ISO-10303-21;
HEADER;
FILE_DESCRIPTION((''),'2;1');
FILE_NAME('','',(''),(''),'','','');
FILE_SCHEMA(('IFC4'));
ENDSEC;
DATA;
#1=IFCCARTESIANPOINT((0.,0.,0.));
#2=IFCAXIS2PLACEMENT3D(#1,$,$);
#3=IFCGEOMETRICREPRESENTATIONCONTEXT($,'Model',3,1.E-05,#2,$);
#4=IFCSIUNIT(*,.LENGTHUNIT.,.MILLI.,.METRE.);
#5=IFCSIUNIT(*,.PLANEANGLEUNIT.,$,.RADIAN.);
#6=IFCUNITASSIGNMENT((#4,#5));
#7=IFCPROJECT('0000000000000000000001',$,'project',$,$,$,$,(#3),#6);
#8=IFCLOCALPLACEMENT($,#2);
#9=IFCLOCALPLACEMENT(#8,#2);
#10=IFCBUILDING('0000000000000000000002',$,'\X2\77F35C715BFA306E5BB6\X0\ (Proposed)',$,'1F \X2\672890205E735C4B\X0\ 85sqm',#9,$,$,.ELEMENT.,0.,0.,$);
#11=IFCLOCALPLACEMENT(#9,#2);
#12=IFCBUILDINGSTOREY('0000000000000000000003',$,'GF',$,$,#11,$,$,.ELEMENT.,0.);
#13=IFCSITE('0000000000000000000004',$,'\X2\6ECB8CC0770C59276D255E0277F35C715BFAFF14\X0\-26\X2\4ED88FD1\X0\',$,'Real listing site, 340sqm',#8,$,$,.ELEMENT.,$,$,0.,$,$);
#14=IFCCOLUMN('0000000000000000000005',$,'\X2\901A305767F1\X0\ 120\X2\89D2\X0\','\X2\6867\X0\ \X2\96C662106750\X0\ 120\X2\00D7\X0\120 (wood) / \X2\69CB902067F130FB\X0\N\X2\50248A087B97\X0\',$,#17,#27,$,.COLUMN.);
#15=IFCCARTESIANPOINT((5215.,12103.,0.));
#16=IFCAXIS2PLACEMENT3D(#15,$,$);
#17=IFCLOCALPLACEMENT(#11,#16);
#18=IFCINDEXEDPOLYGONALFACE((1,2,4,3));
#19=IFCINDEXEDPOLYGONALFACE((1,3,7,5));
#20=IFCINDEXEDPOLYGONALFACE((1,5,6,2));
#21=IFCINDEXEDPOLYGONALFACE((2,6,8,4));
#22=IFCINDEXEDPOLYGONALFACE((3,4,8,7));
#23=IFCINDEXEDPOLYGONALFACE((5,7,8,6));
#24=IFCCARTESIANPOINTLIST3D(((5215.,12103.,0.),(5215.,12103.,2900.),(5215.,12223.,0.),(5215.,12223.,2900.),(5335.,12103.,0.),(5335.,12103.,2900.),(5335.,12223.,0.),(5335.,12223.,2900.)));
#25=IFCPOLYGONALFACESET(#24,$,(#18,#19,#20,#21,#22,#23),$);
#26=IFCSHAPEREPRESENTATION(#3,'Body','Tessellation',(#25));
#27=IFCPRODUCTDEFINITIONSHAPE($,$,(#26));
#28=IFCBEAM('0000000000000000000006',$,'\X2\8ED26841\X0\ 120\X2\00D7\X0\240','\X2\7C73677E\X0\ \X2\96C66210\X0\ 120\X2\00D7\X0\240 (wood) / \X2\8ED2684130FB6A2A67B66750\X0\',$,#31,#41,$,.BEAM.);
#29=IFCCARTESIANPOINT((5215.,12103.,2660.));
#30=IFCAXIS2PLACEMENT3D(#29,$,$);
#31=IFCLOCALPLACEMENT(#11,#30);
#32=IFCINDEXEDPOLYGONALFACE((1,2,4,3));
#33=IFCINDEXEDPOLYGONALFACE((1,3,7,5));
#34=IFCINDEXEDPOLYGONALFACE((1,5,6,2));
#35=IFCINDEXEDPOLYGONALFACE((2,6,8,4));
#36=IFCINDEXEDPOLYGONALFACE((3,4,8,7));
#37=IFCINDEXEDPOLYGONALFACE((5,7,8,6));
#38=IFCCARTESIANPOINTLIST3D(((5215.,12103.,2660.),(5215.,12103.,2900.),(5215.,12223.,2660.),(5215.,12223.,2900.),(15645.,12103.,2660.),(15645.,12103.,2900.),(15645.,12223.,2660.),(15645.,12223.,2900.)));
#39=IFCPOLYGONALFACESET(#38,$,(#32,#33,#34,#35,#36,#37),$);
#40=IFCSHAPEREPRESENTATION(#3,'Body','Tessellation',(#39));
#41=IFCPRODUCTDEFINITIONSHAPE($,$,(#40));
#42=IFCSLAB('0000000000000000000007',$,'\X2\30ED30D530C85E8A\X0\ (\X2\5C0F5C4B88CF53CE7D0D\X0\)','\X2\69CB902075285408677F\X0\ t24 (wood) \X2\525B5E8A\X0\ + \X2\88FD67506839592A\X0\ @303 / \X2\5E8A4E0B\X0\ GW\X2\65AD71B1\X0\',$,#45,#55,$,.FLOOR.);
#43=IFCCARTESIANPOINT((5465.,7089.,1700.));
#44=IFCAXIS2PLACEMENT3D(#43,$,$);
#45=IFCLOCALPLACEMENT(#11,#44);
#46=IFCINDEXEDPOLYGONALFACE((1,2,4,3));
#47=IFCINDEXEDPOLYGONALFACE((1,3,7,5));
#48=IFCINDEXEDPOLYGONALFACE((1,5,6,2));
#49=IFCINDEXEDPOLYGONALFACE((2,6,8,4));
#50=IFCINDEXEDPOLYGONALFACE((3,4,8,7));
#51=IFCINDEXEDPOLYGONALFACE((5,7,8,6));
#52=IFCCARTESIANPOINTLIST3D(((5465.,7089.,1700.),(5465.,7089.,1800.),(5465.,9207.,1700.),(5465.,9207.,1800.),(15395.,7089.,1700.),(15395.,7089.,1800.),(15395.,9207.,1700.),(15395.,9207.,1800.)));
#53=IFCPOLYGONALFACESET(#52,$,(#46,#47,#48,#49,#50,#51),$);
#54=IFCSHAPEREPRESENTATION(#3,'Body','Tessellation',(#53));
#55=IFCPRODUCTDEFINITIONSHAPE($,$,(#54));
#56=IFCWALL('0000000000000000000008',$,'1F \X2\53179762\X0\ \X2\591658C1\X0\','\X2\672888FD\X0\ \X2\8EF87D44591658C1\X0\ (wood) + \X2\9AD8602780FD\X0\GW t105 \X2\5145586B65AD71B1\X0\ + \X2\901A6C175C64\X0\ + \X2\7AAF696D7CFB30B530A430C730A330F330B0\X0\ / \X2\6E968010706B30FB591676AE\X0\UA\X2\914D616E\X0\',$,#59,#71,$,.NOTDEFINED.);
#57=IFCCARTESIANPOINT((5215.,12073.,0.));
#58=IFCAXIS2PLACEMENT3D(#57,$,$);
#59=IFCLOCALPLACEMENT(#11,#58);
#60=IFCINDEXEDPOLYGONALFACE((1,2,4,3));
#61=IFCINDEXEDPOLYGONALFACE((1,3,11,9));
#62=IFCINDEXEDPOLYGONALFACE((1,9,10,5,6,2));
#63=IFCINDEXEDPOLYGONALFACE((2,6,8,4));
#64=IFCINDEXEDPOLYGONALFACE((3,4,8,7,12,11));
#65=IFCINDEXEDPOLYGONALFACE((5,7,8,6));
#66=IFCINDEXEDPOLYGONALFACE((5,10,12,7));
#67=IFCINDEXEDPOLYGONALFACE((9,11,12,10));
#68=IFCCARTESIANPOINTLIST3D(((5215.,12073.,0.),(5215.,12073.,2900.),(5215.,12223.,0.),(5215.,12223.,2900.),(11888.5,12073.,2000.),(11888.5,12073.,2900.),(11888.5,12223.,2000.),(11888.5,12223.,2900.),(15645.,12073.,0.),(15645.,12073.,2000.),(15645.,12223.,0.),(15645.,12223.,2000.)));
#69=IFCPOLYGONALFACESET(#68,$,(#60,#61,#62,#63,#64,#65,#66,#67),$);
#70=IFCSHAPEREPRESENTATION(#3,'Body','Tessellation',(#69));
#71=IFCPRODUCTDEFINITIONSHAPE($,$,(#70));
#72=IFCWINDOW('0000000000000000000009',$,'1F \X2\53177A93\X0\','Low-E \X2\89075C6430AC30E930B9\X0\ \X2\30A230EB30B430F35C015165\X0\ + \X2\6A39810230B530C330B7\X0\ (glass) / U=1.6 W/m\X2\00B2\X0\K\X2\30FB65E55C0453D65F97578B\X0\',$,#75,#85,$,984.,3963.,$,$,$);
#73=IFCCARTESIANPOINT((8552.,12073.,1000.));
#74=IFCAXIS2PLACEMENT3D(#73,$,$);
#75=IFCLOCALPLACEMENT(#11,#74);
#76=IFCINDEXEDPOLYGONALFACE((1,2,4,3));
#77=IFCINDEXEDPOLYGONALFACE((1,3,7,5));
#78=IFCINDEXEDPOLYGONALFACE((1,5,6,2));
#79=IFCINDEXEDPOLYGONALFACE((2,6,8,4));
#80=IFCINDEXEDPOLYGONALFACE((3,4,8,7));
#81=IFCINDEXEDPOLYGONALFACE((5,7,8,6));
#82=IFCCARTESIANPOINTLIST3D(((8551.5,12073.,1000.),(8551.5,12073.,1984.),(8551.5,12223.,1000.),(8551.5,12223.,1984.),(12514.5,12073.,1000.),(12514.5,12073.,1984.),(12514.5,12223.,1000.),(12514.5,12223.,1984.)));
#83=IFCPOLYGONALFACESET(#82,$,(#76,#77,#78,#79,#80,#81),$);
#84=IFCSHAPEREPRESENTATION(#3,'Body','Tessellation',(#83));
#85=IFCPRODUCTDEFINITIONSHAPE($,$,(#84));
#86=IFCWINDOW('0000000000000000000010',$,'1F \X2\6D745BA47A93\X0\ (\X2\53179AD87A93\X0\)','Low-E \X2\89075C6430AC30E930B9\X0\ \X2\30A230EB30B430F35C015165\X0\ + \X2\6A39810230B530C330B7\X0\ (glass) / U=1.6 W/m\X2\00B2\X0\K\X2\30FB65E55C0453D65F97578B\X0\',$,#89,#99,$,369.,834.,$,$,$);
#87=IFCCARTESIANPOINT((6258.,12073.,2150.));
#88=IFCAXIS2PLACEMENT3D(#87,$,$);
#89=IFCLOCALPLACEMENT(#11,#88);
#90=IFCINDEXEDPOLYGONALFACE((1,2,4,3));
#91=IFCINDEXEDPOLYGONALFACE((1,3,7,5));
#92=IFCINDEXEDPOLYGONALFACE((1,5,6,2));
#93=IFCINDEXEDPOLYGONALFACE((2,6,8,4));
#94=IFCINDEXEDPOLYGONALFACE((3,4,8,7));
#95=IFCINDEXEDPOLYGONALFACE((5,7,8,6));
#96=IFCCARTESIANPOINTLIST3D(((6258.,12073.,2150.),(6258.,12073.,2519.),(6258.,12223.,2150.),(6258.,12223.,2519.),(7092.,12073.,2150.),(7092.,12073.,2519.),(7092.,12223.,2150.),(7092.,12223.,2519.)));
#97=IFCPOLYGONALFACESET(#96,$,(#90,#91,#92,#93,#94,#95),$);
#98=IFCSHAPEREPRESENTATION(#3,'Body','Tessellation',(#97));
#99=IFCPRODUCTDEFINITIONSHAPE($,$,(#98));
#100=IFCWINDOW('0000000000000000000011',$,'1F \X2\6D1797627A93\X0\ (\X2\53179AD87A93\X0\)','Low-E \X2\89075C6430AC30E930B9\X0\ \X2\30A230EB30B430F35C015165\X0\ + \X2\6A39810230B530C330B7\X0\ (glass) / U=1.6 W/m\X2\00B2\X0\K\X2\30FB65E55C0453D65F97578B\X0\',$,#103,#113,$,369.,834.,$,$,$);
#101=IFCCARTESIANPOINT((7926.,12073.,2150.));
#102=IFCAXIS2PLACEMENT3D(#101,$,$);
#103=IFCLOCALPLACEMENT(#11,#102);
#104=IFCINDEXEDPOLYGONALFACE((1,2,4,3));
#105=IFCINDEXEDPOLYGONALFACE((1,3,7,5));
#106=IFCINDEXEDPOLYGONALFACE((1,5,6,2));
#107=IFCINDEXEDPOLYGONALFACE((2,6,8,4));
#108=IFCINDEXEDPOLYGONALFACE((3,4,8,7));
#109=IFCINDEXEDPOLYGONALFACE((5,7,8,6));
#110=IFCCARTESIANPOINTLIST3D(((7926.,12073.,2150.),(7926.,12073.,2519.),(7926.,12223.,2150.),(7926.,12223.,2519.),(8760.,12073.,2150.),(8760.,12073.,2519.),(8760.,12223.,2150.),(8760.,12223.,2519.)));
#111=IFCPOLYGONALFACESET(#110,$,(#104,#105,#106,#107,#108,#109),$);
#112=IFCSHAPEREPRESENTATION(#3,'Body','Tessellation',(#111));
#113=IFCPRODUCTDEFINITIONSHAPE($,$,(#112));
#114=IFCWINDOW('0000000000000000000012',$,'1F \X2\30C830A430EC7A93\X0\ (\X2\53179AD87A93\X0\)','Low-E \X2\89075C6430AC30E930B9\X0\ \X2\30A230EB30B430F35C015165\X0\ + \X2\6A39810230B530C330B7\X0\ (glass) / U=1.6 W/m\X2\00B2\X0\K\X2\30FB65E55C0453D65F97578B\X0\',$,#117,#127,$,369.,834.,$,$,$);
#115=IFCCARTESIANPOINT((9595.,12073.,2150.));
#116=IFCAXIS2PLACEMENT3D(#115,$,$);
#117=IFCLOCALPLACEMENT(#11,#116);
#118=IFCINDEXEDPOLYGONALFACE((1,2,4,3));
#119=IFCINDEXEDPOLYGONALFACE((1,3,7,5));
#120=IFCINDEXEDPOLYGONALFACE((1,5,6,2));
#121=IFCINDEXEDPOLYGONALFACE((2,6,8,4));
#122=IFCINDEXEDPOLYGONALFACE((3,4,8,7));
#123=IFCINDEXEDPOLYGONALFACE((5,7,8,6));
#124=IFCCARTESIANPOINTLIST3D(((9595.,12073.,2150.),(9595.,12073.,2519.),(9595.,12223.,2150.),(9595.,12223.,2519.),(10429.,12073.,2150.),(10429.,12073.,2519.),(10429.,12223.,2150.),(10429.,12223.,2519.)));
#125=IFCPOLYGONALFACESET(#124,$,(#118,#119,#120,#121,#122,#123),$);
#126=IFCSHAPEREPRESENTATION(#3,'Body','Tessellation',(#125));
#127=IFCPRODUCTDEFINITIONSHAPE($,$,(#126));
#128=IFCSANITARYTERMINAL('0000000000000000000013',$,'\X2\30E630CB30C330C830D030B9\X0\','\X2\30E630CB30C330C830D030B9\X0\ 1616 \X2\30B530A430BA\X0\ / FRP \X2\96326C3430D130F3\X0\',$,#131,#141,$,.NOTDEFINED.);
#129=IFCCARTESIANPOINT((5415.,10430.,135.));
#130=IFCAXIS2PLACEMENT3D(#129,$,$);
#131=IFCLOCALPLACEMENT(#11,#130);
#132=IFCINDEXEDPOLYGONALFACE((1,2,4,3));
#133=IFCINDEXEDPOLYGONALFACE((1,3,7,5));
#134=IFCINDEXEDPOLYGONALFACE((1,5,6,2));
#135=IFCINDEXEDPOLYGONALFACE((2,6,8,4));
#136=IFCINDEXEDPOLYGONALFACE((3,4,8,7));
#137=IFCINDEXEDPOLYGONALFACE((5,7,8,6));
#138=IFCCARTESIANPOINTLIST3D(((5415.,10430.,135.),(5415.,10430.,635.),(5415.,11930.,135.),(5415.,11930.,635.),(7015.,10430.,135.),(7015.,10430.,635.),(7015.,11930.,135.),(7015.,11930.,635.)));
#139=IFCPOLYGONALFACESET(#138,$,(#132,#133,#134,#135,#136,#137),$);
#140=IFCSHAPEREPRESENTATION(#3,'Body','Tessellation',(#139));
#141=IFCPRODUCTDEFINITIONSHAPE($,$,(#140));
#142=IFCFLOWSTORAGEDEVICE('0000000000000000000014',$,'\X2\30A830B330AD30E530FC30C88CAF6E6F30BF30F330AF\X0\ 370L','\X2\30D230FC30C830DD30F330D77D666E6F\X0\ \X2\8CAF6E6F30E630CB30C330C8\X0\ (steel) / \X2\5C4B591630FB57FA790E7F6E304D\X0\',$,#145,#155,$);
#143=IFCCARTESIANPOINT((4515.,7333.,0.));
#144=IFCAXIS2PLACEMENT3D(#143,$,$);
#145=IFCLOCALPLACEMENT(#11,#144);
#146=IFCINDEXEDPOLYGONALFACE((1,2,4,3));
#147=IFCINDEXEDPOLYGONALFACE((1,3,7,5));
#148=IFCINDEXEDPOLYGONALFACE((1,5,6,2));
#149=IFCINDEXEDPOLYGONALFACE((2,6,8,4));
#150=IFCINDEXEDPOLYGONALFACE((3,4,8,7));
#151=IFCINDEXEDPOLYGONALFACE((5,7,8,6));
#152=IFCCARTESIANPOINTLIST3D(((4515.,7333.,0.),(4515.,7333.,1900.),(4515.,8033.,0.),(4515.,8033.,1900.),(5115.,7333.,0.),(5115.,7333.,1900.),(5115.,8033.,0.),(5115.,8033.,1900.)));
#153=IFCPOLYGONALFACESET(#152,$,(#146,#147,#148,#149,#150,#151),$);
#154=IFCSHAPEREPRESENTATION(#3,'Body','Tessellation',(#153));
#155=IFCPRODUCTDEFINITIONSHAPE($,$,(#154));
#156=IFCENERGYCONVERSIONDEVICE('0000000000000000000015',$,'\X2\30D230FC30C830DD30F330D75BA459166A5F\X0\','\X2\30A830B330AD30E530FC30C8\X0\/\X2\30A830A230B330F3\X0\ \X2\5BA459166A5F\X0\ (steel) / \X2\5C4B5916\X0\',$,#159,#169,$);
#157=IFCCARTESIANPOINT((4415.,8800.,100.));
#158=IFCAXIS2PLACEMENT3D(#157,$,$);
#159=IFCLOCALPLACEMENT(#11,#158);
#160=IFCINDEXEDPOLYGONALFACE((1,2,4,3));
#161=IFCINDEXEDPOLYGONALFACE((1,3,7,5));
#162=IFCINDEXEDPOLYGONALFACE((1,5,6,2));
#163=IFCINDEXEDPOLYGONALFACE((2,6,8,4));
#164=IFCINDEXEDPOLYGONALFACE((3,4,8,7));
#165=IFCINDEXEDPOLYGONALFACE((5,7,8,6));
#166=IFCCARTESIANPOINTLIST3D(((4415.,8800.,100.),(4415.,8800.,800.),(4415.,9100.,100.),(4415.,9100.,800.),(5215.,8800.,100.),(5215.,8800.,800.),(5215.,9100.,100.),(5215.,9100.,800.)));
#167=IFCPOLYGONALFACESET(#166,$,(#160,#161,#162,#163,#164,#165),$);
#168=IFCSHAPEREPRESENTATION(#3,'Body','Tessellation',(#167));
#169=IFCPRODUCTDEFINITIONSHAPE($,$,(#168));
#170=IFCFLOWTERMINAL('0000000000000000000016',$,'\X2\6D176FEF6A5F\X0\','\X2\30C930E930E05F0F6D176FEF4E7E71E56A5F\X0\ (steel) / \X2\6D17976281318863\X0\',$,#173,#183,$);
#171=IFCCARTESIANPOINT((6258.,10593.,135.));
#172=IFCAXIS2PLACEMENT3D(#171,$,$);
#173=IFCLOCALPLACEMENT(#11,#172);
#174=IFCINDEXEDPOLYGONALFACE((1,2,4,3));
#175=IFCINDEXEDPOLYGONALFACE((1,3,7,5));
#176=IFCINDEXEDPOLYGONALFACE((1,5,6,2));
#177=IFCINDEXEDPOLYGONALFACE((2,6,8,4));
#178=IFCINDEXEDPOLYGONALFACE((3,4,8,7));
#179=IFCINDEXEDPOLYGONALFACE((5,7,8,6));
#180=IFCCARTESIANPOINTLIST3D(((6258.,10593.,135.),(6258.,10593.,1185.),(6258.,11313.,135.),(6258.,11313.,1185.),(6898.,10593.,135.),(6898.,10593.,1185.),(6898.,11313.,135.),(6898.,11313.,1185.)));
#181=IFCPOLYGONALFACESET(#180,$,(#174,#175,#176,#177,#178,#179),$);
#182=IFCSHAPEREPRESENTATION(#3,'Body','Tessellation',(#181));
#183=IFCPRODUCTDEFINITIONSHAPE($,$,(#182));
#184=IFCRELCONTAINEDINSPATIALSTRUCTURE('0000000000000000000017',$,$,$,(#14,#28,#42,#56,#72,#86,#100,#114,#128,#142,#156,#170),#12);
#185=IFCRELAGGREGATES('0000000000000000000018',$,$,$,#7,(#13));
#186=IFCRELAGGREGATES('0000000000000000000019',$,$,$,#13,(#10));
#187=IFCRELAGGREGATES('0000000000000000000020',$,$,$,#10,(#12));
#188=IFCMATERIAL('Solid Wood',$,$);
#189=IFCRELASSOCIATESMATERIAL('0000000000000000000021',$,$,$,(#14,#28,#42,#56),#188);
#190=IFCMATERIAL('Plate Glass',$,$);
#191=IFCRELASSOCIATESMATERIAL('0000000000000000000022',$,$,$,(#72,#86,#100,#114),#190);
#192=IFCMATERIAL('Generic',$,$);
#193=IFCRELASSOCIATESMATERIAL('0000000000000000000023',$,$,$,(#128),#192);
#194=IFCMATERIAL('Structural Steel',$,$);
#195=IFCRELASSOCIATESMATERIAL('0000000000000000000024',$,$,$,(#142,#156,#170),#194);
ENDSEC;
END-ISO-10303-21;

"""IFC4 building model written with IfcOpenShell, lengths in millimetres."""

from ifc_helpers import new_model, si_unit, frame, frame_2d, origin, place, context, project, spatial, rectangle, extrude, material, element, fill, save


model = new_model("IFC4")

# Units and contexts
model_context = context("Model", 3, precision=1e-05, world=origin())
ifc_project = project(units=[si_unit("LENGTHUNIT", "METRE", prefix="MILLI"), si_unit("PLANEANGLEUNIT", "RADIAN")], contexts=[model_context])

# Site, building, storey
site_placement = place(None, origin())
site = spatial("IfcSite", under=ifc_project, at=site_placement, Name="滋賀県大津市石山寺４-26付近", ObjectType="Real listing site, 340sqm", CompositionType="ELEMENT", RefElevation=0.0)
building_placement = place(site_placement, origin())
building = spatial("IfcBuilding", under=site, at=building_placement, Name="石山寺の家 (Proposed)", ObjectType="1F 木造平屋 85sqm", CompositionType="ELEMENT", ElevationOfRefHeight=0.0, ElevationOfTerrain=0.0)
storey_placement = place(building_placement, origin())
storey = spatial("IfcBuildingStorey", under=building, at=storey_placement, Name="GF", CompositionType="ELEMENT", Elevation=0.0)

# Column
ifc_material_1 = material(Name="Solid Wood")
column_1_placement = place(storey_placement, frame((5215.0, 12103.0, 0.0)))
element("IfcColumn", 1, at=column_1_placement, inside=storey, material=ifc_material_1, Name="通し柱 120角", Description="桧 集成材 120×120 (wood) / 構造柱・N値計算", PredefinedType="COLUMN", context=model_context, shape_type="SweptSolid", body=[
    extrude(rectangle(XDim=120.0, YDim=120.0, at=frame_2d((60.0, 60.0))), frame((5215.0, 12103.0, 0.0)), (0.0, 0.0, 1.0), 2900.0),
])

# Beam
beam_1_placement = place(storey_placement, frame((5215.0, 12103.0, 2660.0)))
element("IfcBeam", 2, at=beam_1_placement, inside=storey, material=ifc_material_1, Name="軒桁 120×240", Description="米松 集成 120×240 (wood) / 軒桁・横架材", PredefinedType="BEAM", context=model_context, shape_type="SweptSolid", body=[
    extrude(rectangle(XDim=10430.0, YDim=120.0, at=frame_2d((5215.0, 60.0))), frame((5215.0, 12103.0, 2660.0)), (0.0, 0.0, 1.0), 240.0),
])

# Slab
slab_placement = place(storey_placement, frame((5465.0, 7089.0, 1700.0)))
element("IfcSlab", 3, at=slab_placement, inside=storey, material=ifc_material_1, Name="ロフト床 (小屋裏収納)", Description="構造用合板 t24 (wood) 剛床 + 製材根太 @303 / 床下 GW断熱", PredefinedType="FLOOR", context=model_context, shape_type="SweptSolid", body=[
    extrude(rectangle(XDim=9930.0, YDim=2118.0, at=frame_2d((4965.0, 1059.0))), frame((5465.0, 7089.0, 1700.0)), (0.0, 0.0, 1.0), 100.0),
])

# Wall, openings, windows
wall_1_placement = place(storey_placement, frame((5215.0, 12073.0, 0.0)))
wall_1 = element("IfcWall", 4, at=wall_1_placement, inside=storey, material=ifc_material_1, Name="1F 北面 外壁", Description="木製 軸組外壁 (wood) + 高性能GW t105 充填断熱 + 通気層 + 窯業系サイディング / 準耐火・外皮UA配慮", PredefinedType="NOTDEFINED", context=model_context, shape_type="SweptSolid", body=[
    extrude(rectangle(XDim=10430.0, YDim=150.0, at=frame_2d((5215.0, 75.0))), frame((5215.0, 12073.0, 0.0)), (0.0, 0.0, 1.0), 2900.0),
])
opening_1_placement = place(storey_placement, frame((8552.0, 12073.0, 1000.0)))
opening_1 = element("IfcOpeningElement", 5, at=opening_1_placement, cuts=wall_1, PredefinedType="NOTDEFINED", context=model_context, shape_type="SweptSolid", body=[
    extrude(rectangle(XDim=3963.0, YDim=150.0, at=frame_2d((1981.0, 75.0))), frame((8552.0, 12073.0, 1000.0)), (0.0, 0.0, 1.0), 984.0),
])
opening_2_placement = place(storey_placement, frame((6258.0, 12073.0, 2150.0)))
opening_2 = element("IfcOpeningElement", 6, at=opening_2_placement, cuts=wall_1, PredefinedType="NOTDEFINED", context=model_context, shape_type="SweptSolid", body=[
    extrude(rectangle(XDim=834.0, YDim=150.0, at=frame_2d((417.0, 75.0))), frame((6258.0, 12073.0, 2150.0)), (0.0, 0.0, 1.0), 369.0),
])
opening_3_placement = place(storey_placement, frame((7926.0, 12073.0, 2150.0)))
opening_3 = element("IfcOpeningElement", 7, at=opening_3_placement, cuts=wall_1, PredefinedType="NOTDEFINED", context=model_context, shape_type="SweptSolid", body=[
    extrude(rectangle(XDim=834.0, YDim=150.0, at=frame_2d((417.0, 75.0))), frame((7926.0, 12073.0, 2150.0)), (0.0, 0.0, 1.0), 369.0),
])
opening_4_placement = place(storey_placement, frame((9595.0, 12073.0, 2150.0)))
opening_4 = element("IfcOpeningElement", 8, at=opening_4_placement, cuts=wall_1, PredefinedType="NOTDEFINED", context=model_context, shape_type="SweptSolid", body=[
    extrude(rectangle(XDim=834.0, YDim=150.0, at=frame_2d((417.0, 75.0))), frame((9595.0, 12073.0, 2150.0)), (0.0, 0.0, 1.0), 369.0),
])
ifc_material_2 = material(Name="Plate Glass")
window_1_placement = place(storey_placement, frame((8552.0, 12073.0, 1000.0)))
window_1 = element("IfcWindow", 9, at=window_1_placement, inside=storey, material=ifc_material_2, Name="1F 北窓", Description="Low-E 複層ガラス アルゴン封入 + 樹脂サッシ (glass) / U=1.6 W/m²K・日射取得型", OverallHeight=984.0, OverallWidth=3963.0, context=model_context, shape_type="SweptSolid", body=[
    extrude(rectangle(XDim=3963.0, YDim=150.0, at=frame_2d((1981.0, 75.0))), frame((8552.0, 12073.0, 1000.0)), (0.0, 0.0, 1.0), 984.0),
])
fill(opening_1, window_1)
window_2_placement = place(storey_placement, frame((6258.0, 12073.0, 2150.0)))
window_2 = element("IfcWindow", 10, at=window_2_placement, inside=storey, material=ifc_material_2, Name="1F 浴室窓 (北高窓)", Description="Low-E 複層ガラス アルゴン封入 + 樹脂サッシ (glass) / U=1.6 W/m²K・日射取得型", OverallHeight=369.0, OverallWidth=834.0, context=model_context, shape_type="SweptSolid", body=[
    extrude(rectangle(XDim=834.0, YDim=150.0, at=frame_2d((417.0, 75.0))), frame((6258.0, 12073.0, 2150.0)), (0.0, 0.0, 1.0), 369.0),
])
fill(opening_2, window_2)
window_3_placement = place(storey_placement, frame((7926.0, 12073.0, 2150.0)))
window_3 = element("IfcWindow", 11, at=window_3_placement, inside=storey, material=ifc_material_2, Name="1F 洗面窓 (北高窓)", Description="Low-E 複層ガラス アルゴン封入 + 樹脂サッシ (glass) / U=1.6 W/m²K・日射取得型", OverallHeight=369.0, OverallWidth=834.0, context=model_context, shape_type="SweptSolid", body=[
    extrude(rectangle(XDim=834.0, YDim=150.0, at=frame_2d((417.0, 75.0))), frame((7926.0, 12073.0, 2150.0)), (0.0, 0.0, 1.0), 369.0),
])
fill(opening_3, window_3)
window_4_placement = place(storey_placement, frame((9595.0, 12073.0, 2150.0)))
window_4 = element("IfcWindow", 12, at=window_4_placement, inside=storey, material=ifc_material_2, Name="1F トイレ窓 (北高窓)", Description="Low-E 複層ガラス アルゴン封入 + 樹脂サッシ (glass) / U=1.6 W/m²K・日射取得型", OverallHeight=369.0, OverallWidth=834.0, context=model_context, shape_type="SweptSolid", body=[
    extrude(rectangle(XDim=834.0, YDim=150.0, at=frame_2d((417.0, 75.0))), frame((9595.0, 12073.0, 2150.0)), (0.0, 0.0, 1.0), 369.0),
])
fill(opening_4, window_4)

# Sanitary terminal
ifc_material_3 = material(Name="Generic")
sanitary_terminal_placement = place(storey_placement, frame((5415.0, 10430.0, 135.0)))
element("IfcSanitaryTerminal", 13, at=sanitary_terminal_placement, inside=storey, material=ifc_material_3, Name="ユニットバス", Description="ユニットバス 1616 サイズ / FRP 防水パン", PredefinedType="NOTDEFINED", context=model_context, shape_type="SweptSolid", body=[
    extrude(rectangle(XDim=1600.0, YDim=1500.0, at=frame_2d((800.0, 750.0))), frame((5415.0, 10430.0, 135.0)), (0.0, 0.0, 1.0), 500.0),
])

# Flow storage device
ifc_material_4 = material(Name="Structural Steel")
flow_storage_device_placement = place(storey_placement, frame((4515.0, 7333.0, 0.0)))
element("IfcFlowStorageDevice", 14, at=flow_storage_device_placement, inside=storey, material=ifc_material_4, Name="エコキュート貯湯タンク 370L", Description="ヒートポンプ給湯 貯湯ユニット (steel) / 屋外・基礎置き", context=model_context, shape_type="SweptSolid", body=[
    extrude(rectangle(XDim=600.0, YDim=700.0, at=frame_2d((300.0, 350.0))), frame((4515.0, 7333.0, 0.0)), (0.0, 0.0, 1.0), 1900.0),
])

# Energy conversion device
energy_conversion_device_placement = place(storey_placement, frame((4415.0, 8800.0, 100.0)))
element("IfcEnergyConversionDevice", 15, at=energy_conversion_device_placement, inside=storey, material=ifc_material_4, Name="ヒートポンプ室外機", Description="エコキュート/エアコン 室外機 (steel) / 屋外", context=model_context, shape_type="SweptSolid", body=[
    extrude(rectangle(XDim=800.0, YDim=300.0, at=frame_2d((400.0, 150.0))), frame((4415.0, 8800.0, 100.0)), (0.0, 0.0, 1.0), 700.0),
])

# Flow terminal
flow_terminal_placement = place(storey_placement, frame((6258.0, 10593.0, 135.0)))
element("IfcFlowTerminal", 16, at=flow_terminal_placement, inside=storey, material=ifc_material_4, Name="洗濯機", Description="ドラム式洗濯乾燥機 (steel) / 洗面脱衣", context=model_context, shape_type="SweptSolid", body=[
    extrude(rectangle(XDim=640.0, YDim=720.0, at=frame_2d((320.0, 360.0))), frame((6258.0, 10593.0, 135.0)), (0.0, 0.0, 1.0), 1050.0),
])

save(model, "model.ifc")
